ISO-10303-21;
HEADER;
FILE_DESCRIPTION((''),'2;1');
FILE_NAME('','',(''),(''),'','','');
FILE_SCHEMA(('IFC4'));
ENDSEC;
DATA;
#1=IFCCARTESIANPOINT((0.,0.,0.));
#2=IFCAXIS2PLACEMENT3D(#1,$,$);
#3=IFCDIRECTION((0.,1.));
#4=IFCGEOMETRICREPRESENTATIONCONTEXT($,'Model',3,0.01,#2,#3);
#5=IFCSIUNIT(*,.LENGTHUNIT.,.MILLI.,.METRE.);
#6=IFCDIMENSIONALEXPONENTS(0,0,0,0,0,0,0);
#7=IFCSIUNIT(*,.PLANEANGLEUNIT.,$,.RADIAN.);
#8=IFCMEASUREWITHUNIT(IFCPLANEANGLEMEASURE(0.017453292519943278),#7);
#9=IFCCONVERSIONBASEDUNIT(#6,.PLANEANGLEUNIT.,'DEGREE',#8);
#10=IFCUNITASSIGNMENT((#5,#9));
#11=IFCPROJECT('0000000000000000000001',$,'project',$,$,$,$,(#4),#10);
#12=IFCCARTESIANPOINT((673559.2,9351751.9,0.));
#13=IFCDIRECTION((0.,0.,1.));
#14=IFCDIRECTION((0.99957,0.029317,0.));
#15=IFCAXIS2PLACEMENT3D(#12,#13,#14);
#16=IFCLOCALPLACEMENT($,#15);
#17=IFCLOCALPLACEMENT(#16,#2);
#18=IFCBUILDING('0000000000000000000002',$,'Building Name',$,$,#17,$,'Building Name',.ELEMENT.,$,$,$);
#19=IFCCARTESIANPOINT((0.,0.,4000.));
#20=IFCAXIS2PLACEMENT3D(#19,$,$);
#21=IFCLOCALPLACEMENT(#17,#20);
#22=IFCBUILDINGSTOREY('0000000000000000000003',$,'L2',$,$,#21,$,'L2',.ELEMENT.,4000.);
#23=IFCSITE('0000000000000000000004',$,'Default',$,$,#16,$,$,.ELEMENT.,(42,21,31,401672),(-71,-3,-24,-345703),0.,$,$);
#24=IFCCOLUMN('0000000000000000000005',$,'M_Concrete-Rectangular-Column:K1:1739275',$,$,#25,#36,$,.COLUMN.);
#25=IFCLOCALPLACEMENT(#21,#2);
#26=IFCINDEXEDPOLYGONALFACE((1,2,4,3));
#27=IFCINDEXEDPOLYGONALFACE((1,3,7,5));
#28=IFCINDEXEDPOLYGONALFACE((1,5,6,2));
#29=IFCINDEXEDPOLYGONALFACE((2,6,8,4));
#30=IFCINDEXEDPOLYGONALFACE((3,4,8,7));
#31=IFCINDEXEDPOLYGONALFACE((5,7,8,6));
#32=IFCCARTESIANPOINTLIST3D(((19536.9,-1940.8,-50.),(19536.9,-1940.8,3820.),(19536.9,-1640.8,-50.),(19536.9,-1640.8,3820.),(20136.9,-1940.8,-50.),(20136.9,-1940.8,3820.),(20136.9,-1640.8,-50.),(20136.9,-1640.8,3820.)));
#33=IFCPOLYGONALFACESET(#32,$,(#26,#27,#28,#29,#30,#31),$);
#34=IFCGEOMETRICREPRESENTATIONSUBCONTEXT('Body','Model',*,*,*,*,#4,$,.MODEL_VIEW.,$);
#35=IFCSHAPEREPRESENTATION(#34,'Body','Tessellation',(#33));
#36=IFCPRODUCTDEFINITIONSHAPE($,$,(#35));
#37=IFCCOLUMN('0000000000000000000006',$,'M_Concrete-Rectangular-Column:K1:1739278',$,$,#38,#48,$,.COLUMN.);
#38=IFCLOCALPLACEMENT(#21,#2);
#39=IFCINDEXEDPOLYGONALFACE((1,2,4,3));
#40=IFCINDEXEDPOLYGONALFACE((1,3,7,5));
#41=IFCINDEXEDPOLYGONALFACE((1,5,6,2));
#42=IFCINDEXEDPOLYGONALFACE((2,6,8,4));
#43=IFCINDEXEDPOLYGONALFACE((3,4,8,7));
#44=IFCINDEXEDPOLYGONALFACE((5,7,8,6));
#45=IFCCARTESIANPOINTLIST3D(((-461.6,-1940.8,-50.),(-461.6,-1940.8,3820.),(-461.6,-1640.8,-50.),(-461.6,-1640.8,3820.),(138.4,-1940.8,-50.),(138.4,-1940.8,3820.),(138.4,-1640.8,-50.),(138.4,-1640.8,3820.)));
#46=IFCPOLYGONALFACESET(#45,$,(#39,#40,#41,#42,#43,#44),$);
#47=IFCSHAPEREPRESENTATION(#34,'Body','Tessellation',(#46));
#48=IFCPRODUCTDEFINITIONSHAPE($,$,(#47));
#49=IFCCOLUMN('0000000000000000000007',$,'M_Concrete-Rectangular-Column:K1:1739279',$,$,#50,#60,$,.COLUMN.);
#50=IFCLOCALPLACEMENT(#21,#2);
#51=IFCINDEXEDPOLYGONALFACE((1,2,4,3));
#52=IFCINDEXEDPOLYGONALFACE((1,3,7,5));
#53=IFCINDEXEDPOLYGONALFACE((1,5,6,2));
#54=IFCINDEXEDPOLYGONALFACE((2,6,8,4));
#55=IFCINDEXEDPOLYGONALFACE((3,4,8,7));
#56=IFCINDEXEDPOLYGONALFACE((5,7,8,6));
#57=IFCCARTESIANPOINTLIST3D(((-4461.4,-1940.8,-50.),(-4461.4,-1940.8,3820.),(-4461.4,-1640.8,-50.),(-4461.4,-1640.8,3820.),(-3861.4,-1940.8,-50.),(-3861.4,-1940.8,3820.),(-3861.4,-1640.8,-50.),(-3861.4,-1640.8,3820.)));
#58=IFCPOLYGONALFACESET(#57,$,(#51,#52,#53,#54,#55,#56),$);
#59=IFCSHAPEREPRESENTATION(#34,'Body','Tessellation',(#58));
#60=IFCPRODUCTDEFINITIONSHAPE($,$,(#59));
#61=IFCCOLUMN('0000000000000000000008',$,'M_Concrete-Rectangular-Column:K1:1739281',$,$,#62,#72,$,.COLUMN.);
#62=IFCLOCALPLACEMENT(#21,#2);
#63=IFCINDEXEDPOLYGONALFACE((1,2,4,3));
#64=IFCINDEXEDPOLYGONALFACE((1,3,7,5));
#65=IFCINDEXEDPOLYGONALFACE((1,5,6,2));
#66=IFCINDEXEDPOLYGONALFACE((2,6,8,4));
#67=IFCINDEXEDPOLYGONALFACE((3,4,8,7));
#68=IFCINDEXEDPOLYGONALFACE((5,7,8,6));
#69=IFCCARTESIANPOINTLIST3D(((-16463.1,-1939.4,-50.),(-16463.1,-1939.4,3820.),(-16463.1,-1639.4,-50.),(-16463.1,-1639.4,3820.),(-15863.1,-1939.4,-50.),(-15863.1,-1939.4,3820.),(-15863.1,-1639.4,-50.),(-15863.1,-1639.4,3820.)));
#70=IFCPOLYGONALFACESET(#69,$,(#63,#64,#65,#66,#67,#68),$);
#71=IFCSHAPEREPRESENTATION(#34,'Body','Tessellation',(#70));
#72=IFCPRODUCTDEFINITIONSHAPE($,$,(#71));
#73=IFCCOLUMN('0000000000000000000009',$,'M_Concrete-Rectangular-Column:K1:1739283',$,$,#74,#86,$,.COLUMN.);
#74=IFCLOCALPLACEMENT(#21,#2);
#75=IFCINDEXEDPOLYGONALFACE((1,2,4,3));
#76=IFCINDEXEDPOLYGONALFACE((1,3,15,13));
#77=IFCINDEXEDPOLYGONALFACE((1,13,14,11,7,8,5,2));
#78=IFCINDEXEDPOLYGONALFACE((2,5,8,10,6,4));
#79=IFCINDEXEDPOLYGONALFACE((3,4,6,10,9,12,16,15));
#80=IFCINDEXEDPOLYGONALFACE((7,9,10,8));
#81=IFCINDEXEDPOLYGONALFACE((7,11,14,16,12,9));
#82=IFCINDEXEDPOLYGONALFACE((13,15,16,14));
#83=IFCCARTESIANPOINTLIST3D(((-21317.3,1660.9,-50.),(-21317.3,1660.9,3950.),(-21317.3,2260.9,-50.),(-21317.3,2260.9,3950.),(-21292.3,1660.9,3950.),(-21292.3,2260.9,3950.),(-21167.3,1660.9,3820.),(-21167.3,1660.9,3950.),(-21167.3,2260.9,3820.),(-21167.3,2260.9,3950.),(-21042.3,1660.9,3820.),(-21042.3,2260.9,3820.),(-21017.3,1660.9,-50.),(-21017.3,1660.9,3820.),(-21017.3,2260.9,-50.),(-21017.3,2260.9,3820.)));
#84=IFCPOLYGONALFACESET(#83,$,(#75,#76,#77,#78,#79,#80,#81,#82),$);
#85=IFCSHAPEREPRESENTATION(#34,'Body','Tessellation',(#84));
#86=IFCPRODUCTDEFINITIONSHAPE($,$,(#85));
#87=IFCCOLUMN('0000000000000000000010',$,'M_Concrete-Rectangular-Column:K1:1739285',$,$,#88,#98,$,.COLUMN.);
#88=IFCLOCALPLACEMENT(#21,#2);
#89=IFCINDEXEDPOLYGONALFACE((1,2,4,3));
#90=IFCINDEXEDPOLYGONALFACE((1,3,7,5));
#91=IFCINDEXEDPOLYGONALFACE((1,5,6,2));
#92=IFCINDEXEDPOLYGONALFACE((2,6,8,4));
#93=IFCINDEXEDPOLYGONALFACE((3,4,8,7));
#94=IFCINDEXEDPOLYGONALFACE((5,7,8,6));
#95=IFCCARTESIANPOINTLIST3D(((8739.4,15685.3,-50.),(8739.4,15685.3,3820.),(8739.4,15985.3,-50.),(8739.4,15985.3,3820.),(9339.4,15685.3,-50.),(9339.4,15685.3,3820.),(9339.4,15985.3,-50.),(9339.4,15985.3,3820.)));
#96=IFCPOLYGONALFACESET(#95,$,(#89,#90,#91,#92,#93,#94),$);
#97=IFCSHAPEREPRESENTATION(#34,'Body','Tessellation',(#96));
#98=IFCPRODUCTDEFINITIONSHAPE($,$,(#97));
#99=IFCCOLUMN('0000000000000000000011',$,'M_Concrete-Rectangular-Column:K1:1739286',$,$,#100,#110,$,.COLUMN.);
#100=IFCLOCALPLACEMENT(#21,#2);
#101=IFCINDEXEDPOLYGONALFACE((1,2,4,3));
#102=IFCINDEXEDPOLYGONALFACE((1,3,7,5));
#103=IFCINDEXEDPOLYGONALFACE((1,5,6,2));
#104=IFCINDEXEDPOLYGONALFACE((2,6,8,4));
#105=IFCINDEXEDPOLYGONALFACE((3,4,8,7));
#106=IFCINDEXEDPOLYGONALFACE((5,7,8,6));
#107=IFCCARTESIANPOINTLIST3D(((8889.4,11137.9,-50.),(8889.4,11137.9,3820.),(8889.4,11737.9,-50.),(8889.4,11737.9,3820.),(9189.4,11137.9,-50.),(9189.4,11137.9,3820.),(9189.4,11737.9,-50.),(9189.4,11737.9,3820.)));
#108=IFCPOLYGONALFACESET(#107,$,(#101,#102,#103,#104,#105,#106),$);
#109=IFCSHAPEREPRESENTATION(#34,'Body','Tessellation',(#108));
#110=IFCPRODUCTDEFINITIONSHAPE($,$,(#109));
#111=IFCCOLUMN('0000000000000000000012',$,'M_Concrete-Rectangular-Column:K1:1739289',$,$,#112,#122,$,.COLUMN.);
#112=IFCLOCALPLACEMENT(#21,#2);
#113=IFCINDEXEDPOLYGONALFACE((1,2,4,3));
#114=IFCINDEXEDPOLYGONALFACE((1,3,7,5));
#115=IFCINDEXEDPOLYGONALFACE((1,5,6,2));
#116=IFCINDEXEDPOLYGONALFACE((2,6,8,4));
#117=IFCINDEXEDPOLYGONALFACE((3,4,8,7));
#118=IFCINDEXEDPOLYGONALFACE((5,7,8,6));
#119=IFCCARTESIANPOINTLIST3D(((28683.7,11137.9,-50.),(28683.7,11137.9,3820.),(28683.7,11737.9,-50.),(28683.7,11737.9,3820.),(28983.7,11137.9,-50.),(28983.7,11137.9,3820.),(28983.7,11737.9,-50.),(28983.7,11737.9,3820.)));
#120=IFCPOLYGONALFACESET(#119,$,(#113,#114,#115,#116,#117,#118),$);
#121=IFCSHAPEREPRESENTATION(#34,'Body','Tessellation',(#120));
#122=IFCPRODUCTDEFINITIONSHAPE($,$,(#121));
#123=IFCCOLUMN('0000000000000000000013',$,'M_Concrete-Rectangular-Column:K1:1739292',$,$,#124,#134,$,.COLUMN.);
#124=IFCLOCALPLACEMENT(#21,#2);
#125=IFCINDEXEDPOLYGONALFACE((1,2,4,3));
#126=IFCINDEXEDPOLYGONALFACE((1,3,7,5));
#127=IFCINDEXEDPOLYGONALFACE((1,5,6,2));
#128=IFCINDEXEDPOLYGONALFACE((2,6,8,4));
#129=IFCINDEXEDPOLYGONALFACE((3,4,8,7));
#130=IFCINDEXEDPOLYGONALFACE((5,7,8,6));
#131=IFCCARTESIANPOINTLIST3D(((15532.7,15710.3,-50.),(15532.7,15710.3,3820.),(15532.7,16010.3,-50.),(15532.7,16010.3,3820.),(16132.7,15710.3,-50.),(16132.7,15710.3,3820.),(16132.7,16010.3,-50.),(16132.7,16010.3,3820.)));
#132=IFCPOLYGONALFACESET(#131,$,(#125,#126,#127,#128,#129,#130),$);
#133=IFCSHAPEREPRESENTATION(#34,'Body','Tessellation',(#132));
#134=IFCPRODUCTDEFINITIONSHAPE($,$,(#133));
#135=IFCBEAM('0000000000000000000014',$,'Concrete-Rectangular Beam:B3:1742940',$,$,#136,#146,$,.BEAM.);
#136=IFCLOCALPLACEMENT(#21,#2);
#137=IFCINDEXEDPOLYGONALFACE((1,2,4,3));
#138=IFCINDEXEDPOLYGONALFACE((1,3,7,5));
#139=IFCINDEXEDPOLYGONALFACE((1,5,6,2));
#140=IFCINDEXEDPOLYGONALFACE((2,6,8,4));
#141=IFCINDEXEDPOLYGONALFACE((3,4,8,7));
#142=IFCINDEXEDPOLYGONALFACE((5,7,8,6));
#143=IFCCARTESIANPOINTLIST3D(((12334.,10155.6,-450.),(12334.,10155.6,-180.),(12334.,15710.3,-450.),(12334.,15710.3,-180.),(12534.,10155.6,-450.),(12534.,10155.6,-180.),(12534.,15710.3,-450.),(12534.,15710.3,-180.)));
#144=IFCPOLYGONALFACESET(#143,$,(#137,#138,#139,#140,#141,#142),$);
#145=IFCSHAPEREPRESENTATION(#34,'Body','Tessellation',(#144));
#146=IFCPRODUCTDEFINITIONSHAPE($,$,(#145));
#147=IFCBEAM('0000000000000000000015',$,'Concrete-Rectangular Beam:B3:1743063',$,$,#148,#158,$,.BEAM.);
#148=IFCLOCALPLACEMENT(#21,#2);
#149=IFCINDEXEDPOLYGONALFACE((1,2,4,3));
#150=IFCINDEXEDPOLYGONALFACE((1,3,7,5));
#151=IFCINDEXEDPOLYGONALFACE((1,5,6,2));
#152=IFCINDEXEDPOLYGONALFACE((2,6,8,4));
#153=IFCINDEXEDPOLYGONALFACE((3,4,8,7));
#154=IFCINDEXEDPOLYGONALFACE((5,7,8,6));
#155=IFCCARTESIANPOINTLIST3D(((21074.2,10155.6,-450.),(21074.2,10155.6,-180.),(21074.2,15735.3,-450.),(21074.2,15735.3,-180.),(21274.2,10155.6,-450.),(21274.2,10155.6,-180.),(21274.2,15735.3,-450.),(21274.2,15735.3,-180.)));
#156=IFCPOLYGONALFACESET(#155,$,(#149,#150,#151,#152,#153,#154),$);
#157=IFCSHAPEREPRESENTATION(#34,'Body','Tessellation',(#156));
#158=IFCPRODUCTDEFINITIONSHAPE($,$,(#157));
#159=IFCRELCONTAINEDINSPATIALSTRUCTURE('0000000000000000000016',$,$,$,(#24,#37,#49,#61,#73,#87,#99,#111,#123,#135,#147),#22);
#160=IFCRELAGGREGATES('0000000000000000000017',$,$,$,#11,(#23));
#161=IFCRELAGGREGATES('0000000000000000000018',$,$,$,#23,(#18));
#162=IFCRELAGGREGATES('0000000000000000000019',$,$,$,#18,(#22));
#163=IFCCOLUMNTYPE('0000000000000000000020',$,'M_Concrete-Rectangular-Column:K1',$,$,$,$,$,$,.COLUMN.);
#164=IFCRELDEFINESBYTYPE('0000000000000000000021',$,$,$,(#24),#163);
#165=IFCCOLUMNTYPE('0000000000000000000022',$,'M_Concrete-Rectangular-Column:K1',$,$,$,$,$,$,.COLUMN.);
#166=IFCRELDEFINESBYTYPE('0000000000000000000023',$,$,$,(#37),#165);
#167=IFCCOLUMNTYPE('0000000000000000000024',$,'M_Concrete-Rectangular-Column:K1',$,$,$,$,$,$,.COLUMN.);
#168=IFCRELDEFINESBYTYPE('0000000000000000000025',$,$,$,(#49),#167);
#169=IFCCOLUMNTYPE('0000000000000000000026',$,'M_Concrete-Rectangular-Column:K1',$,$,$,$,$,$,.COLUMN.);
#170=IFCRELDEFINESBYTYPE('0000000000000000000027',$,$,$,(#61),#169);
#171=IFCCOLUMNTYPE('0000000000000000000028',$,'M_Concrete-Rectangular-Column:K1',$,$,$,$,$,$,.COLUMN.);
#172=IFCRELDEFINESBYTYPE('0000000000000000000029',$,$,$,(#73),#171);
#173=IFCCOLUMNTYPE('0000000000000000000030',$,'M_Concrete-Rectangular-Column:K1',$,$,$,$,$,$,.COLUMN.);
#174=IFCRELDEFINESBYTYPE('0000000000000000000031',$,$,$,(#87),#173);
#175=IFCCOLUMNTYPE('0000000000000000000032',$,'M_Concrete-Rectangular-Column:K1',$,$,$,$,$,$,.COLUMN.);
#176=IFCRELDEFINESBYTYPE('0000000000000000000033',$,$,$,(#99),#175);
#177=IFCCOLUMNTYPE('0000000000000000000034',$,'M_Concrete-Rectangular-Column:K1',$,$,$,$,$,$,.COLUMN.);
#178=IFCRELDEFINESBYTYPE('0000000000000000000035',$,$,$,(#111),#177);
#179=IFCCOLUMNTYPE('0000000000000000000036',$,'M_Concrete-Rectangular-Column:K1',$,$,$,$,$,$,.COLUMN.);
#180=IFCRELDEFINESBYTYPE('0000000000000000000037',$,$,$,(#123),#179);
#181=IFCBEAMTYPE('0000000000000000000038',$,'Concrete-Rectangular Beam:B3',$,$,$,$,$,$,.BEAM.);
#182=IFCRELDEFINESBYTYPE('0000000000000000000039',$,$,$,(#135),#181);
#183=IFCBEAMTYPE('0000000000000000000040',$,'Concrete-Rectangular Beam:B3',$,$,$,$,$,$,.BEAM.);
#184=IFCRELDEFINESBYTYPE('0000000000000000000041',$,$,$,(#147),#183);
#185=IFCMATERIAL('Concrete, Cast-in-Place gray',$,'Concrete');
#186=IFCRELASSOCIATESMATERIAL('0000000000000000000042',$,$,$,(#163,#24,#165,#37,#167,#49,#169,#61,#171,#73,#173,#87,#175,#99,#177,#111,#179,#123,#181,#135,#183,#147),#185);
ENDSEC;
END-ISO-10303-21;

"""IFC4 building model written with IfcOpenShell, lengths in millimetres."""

from ifc_helpers import new_model, entity, si_unit, converted_unit, direction, frame, origin, place, context, subcontext, project, spatial, indexed_curve, outline, extrude, source, transform, mapped, material, type_object, type_shapes, element, save


model = new_model("IFC4")

# Units and contexts
model_context = context("Model", 3, precision=0.01, world=origin(), true_north=direction((0.0, 1.0)))
body_context = subcontext(model_context, "Body", "Model", "MODEL_VIEW")
ifc_project = project(units=[si_unit("LENGTHUNIT", "METRE", prefix="MILLI"), converted_unit("PLANEANGLEUNIT", "DEGREE", entity("IfcPlaneAngleMeasure", 0.017453292519943278), si_unit("PLANEANGLEUNIT", "RADIAN"), dimensions=[0, 0, 0, 0, 0, 0, 0])], contexts=[model_context])

# Site, building, storey
site_placement = place(None, frame((673559.2, 9351751.9, 0.0), z_axis=(0.0, 0.0, 1.0), x_axis=(0.99957, 0.029317, 0.0)))
site = spatial("IfcSite", under=ifc_project, at=site_placement, Name="Default", CompositionType="ELEMENT", RefLatitude=(42, 21, 31, 401672), RefLongitude=(-71, -3, -24, -345703), RefElevation=0.0)
building_placement = place(site_placement, origin())
building = spatial("IfcBuilding", under=site, at=building_placement, Name="Building Name", LongName="Building Name", CompositionType="ELEMENT")
storey_placement = place(building_placement, frame((0.0, 0.0, 4000.0)))
storey = spatial("IfcBuildingStorey", under=building, at=storey_placement, Name="L2", LongName="L2", CompositionType="ELEMENT", Elevation=4000.0)

# Columns
ifc_material = material(Name="Concrete, Cast-in-Place gray", Category="Concrete")
column_type_1 = type_object("IfcColumnType", Name="M_Concrete-Rectangular-Column:K1", PredefinedType="COLUMN", material=ifc_material)
shared_shape_1 = source(origin(), body_context, "Body", "SweptSolid", [
    extrude(outline(indexed_curve([(-150.0, -300.0), (150.0, -300.0), (150.0, 300.0), (-150.0, 300.0), (-150.0, -300.0)], self_intersect=False)), frame((19836.9, -1790.8, 3950.0), z_axis=(0.0, 0.0, 1.0), x_axis=(0.0, -1.0, 0.0)), (0.0, 0.0, 1.0), 3870.0),
])
type_shapes(column_type_1, [shared_shape_1])
column_1_placement = place(storey_placement, frame((0.0, 0.0, -4000.0)))
element("IfcColumn", 1, at=column_1_placement, inside=storey, type_object=column_type_1, material=ifc_material, Name="M_Concrete-Rectangular-Column:K1:1739275", PredefinedType="COLUMN", context=body_context, shape_type="MappedRepresentation", body=[
    mapped(shared_shape_1, transform((0.0, 0.0, 0.0), scale=1.0)),
])
column_type_2 = type_object("IfcColumnType", Name="M_Concrete-Rectangular-Column:K1", PredefinedType="COLUMN", material=ifc_material)
shared_shape_2 = source(origin(), body_context, "Body", "SweptSolid", [
    extrude(outline(indexed_curve([(-150.0, -300.0), (150.0, -300.0), (150.0, 300.0), (-150.0, 300.0), (-150.0, -300.0)], self_intersect=False)), frame((-161.6, -1790.8, 3950.0), z_axis=(0.0, 0.0, 1.0), x_axis=(0.0, -1.0, 0.0)), (0.0, 0.0, 1.0), 3870.0),
])
type_shapes(column_type_2, [shared_shape_2])
column_2_placement = place(storey_placement, frame((0.0, 0.0, -4000.0)))
element("IfcColumn", 2, at=column_2_placement, inside=storey, type_object=column_type_2, material=ifc_material, Name="M_Concrete-Rectangular-Column:K1:1739278", PredefinedType="COLUMN", context=body_context, shape_type="MappedRepresentation", body=[
    mapped(shared_shape_2, transform((0.0, 0.0, 0.0), scale=1.0)),
])
column_type_3 = type_object("IfcColumnType", Name="M_Concrete-Rectangular-Column:K1", PredefinedType="COLUMN", material=ifc_material)
shared_shape_3 = source(origin(), body_context, "Body", "SweptSolid", [
    extrude(outline(indexed_curve([(-150.0, -300.0), (150.0, -300.0), (150.0, 300.0), (-150.0, 300.0), (-150.0, -300.0)], self_intersect=False)), frame((-4161.4, -1790.8, 3950.0), z_axis=(0.0, 0.0, 1.0), x_axis=(0.0, -1.0, 0.0)), (0.0, 0.0, 1.0), 3870.0),
])
type_shapes(column_type_3, [shared_shape_3])
column_3_placement = place(storey_placement, frame((0.0, 0.0, -4000.0)))
element("IfcColumn", 3, at=column_3_placement, inside=storey, type_object=column_type_3, material=ifc_material, Name="M_Concrete-Rectangular-Column:K1:1739279", PredefinedType="COLUMN", context=body_context, shape_type="MappedRepresentation", body=[
    mapped(shared_shape_3, transform((0.0, 0.0, 0.0), scale=1.0)),
])
column_type_4 = type_object("IfcColumnType", Name="M_Concrete-Rectangular-Column:K1", PredefinedType="COLUMN", material=ifc_material)
shared_shape_4 = source(origin(), body_context, "Body", "SweptSolid", [
    extrude(outline(indexed_curve([(-150.0, -300.0), (150.0, -300.0), (150.0, 300.0), (-150.0, 300.0), (-150.0, -300.0)], self_intersect=False)), frame((-16163.1, -1789.4, 3950.0), z_axis=(0.0, 0.0, 1.0), x_axis=(0.0, -1.0, 0.0)), (0.0, 0.0, 1.0), 3870.0),
])
type_shapes(column_type_4, [shared_shape_4])
column_4_placement = place(storey_placement, frame((0.0, 0.0, -4000.0)))
element("IfcColumn", 4, at=column_4_placement, inside=storey, type_object=column_type_4, material=ifc_material, Name="M_Concrete-Rectangular-Column:K1:1739281", PredefinedType="COLUMN", context=body_context, shape_type="MappedRepresentation", body=[
    mapped(shared_shape_4, transform((0.0, 0.0, 0.0), scale=1.0)),
])
column_type_5 = type_object("IfcColumnType", Name="M_Concrete-Rectangular-Column:K1", PredefinedType="COLUMN", material=ifc_material)
shared_shape_5 = source(origin(), body_context, "Body", "SweptSolid", [
    extrude(outline(indexed_curve([(-2951.3, -150.0), (1048.7, -150.0), (1048.7, -125.0), (1048.7, 0.0), (918.8, 0.0), (918.8, 125.0), (918.8, 150.0), (-2951.3, 150.0), (-2951.3, -150.0)], self_intersect=False)), frame((-21167.3, 1660.9, 6901.3), z_axis=(0.0, 1.0, 0.0), x_axis=(0.0, 0.0, 1.0)), (0.0, 0.0, 1.0), 600.0),
])
type_shapes(column_type_5, [shared_shape_5])
column_5_placement = place(storey_placement, frame((0.0, 0.0, -4000.0)))
element("IfcColumn", 5, at=column_5_placement, inside=storey, type_object=column_type_5, material=ifc_material, Name="M_Concrete-Rectangular-Column:K1:1739283", PredefinedType="COLUMN", context=body_context, shape_type="MappedRepresentation", body=[
    mapped(shared_shape_5, transform((0.0, 0.0, 0.0), scale=1.0)),
])
column_type_6 = type_object("IfcColumnType", Name="M_Concrete-Rectangular-Column:K1", PredefinedType="COLUMN", material=ifc_material)
shared_shape_6 = source(origin(), body_context, "Body", "SweptSolid", [
    extrude(outline(indexed_curve([(-150.0, -300.0), (150.0, -300.0), (150.0, 300.0), (-150.0, 300.0), (-150.0, -300.0)], self_intersect=False)), frame((9039.4, 15835.3, 3950.0), z_axis=(0.0, 0.0, 1.0), x_axis=(0.0, -1.0, 0.0)), (0.0, 0.0, 1.0), 3870.0),
])
type_shapes(column_type_6, [shared_shape_6])
column_6_placement = place(storey_placement, frame((0.0, 0.0, -4000.0)))
element("IfcColumn", 6, at=column_6_placement, inside=storey, type_object=column_type_6, material=ifc_material, Name="M_Concrete-Rectangular-Column:K1:1739285", PredefinedType="COLUMN", context=body_context, shape_type="MappedRepresentation", body=[
    mapped(shared_shape_6, transform((0.0, 0.0, 0.0), scale=1.0)),
])
column_type_7 = type_object("IfcColumnType", Name="M_Concrete-Rectangular-Column:K1", PredefinedType="COLUMN", material=ifc_material)
shared_shape_7 = source(origin(), body_context, "Body", "SweptSolid", [
    extrude(outline(indexed_curve([(-1935.0, -300.0), (1935.0, -300.0), (1935.0, 300.0), (-1935.0, 300.0), (-1935.0, -300.0)], self_intersect=False)), frame((8889.4, 11437.9, 5885.0), z_axis=(1.0, 0.0, 0.0), x_axis=(0.0, 0.0, 1.0)), (0.0, 0.0, 1.0), 300.0),
])
type_shapes(column_type_7, [shared_shape_7])
column_7_placement = place(storey_placement, frame((0.0, 0.0, -4000.0)))
element("IfcColumn", 7, at=column_7_placement, inside=storey, type_object=column_type_7, material=ifc_material, Name="M_Concrete-Rectangular-Column:K1:1739286", PredefinedType="COLUMN", context=body_context, shape_type="MappedRepresentation", body=[
    mapped(shared_shape_7, transform((0.0, 0.0, 0.0), scale=1.0)),
])
column_type_8 = type_object("IfcColumnType", Name="M_Concrete-Rectangular-Column:K1", PredefinedType="COLUMN", material=ifc_material)
shared_shape_8 = source(origin(), body_context, "Body", "SweptSolid", [
    extrude(outline(indexed_curve([(-150.0, -300.0), (150.0, -300.0), (150.0, 300.0), (-150.0, 300.0), (-150.0, -300.0)], self_intersect=False)), frame((28833.7, 11437.9, 3950.0), z_axis=(0.0, 0.0, 1.0), x_axis=(-1.0, 0.0, 0.0)), (0.0, 0.0, 1.0), 3870.0),
])
type_shapes(column_type_8, [shared_shape_8])
column_8_placement = place(storey_placement, frame((0.0, 0.0, -4000.0)))
element("IfcColumn", 8, at=column_8_placement, inside=storey, type_object=column_type_8, material=ifc_material, Name="M_Concrete-Rectangular-Column:K1:1739289", PredefinedType="COLUMN", context=body_context, shape_type="MappedRepresentation", body=[
    mapped(shared_shape_8, transform((0.0, 0.0, 0.0), scale=1.0)),
])
column_type_9 = type_object("IfcColumnType", Name="M_Concrete-Rectangular-Column:K1", PredefinedType="COLUMN", material=ifc_material)
shared_shape_9 = source(origin(), body_context, "Body", "SweptSolid", [
    extrude(outline(indexed_curve([(-150.0, -300.0), (150.0, -300.0), (150.0, 300.0), (-150.0, 300.0), (-150.0, -300.0)], self_intersect=False)), frame((15832.7, 15860.3, 3950.0), z_axis=(0.0, 0.0, 1.0), x_axis=(0.0, -1.0, 0.0)), (0.0, 0.0, 1.0), 3870.0),
])
type_shapes(column_type_9, [shared_shape_9])
column_9_placement = place(storey_placement, frame((0.0, 0.0, -4000.0)))
element("IfcColumn", 9, at=column_9_placement, inside=storey, type_object=column_type_9, material=ifc_material, Name="M_Concrete-Rectangular-Column:K1:1739292", PredefinedType="COLUMN", context=body_context, shape_type="MappedRepresentation", body=[
    mapped(shared_shape_9, transform((0.0, 0.0, 0.0), scale=1.0)),
])

# Beams
beam_type_1 = type_object("IfcBeamType", Name="Concrete-Rectangular Beam:B3", PredefinedType="BEAM", material=ifc_material)
shared_shape_10 = source(origin(), body_context, "Body", "SweptSolid", [
    extrude(outline(indexed_curve([(-100.0, -135.0), (100.0, -135.0), (100.0, 135.0), (-100.0, 135.0), (-100.0, -135.0)], self_intersect=False)), frame((12434.0, 15710.3, 3685.0), z_axis=(0.0, -1.0, 0.0), x_axis=(-1.0, 0.0, 0.0)), (0.0, 0.0, 1.0), 5554.7),
])
type_shapes(beam_type_1, [shared_shape_10])
beam_1_placement = place(storey_placement, frame((0.0, 0.0, -4000.0)))
element("IfcBeam", 10, at=beam_1_placement, inside=storey, type_object=beam_type_1, material=ifc_material, Name="Concrete-Rectangular Beam:B3:1742940", PredefinedType="BEAM", context=body_context, shape_type="MappedRepresentation", body=[
    mapped(shared_shape_10, transform((0.0, 0.0, 0.0), scale=1.0)),
])
beam_type_2 = type_object("IfcBeamType", Name="Concrete-Rectangular Beam:B3", PredefinedType="BEAM", material=ifc_material)
shared_shape_11 = source(origin(), body_context, "Body", "SweptSolid", [
    extrude(outline(indexed_curve([(-100.0, -135.0), (100.0, -135.0), (100.0, 135.0), (-100.0, 135.0), (-100.0, -135.0)], self_intersect=False)), frame((21174.2, 15735.3, 3685.0), z_axis=(0.0, -1.0, 0.0), x_axis=(-1.0, 0.0, 0.0)), (0.0, 0.0, 1.0), 5579.7),
])
type_shapes(beam_type_2, [shared_shape_11])
beam_2_placement = place(storey_placement, frame((0.0, 0.0, -4000.0)))
element("IfcBeam", 11, at=beam_2_placement, inside=storey, type_object=beam_type_2, material=ifc_material, Name="Concrete-Rectangular Beam:B3:1743063", PredefinedType="BEAM", context=body_context, shape_type="MappedRepresentation", body=[
    mapped(shared_shape_11, transform((0.0, 0.0, 0.0), scale=1.0)),
])

save(model, "model.ifc")
